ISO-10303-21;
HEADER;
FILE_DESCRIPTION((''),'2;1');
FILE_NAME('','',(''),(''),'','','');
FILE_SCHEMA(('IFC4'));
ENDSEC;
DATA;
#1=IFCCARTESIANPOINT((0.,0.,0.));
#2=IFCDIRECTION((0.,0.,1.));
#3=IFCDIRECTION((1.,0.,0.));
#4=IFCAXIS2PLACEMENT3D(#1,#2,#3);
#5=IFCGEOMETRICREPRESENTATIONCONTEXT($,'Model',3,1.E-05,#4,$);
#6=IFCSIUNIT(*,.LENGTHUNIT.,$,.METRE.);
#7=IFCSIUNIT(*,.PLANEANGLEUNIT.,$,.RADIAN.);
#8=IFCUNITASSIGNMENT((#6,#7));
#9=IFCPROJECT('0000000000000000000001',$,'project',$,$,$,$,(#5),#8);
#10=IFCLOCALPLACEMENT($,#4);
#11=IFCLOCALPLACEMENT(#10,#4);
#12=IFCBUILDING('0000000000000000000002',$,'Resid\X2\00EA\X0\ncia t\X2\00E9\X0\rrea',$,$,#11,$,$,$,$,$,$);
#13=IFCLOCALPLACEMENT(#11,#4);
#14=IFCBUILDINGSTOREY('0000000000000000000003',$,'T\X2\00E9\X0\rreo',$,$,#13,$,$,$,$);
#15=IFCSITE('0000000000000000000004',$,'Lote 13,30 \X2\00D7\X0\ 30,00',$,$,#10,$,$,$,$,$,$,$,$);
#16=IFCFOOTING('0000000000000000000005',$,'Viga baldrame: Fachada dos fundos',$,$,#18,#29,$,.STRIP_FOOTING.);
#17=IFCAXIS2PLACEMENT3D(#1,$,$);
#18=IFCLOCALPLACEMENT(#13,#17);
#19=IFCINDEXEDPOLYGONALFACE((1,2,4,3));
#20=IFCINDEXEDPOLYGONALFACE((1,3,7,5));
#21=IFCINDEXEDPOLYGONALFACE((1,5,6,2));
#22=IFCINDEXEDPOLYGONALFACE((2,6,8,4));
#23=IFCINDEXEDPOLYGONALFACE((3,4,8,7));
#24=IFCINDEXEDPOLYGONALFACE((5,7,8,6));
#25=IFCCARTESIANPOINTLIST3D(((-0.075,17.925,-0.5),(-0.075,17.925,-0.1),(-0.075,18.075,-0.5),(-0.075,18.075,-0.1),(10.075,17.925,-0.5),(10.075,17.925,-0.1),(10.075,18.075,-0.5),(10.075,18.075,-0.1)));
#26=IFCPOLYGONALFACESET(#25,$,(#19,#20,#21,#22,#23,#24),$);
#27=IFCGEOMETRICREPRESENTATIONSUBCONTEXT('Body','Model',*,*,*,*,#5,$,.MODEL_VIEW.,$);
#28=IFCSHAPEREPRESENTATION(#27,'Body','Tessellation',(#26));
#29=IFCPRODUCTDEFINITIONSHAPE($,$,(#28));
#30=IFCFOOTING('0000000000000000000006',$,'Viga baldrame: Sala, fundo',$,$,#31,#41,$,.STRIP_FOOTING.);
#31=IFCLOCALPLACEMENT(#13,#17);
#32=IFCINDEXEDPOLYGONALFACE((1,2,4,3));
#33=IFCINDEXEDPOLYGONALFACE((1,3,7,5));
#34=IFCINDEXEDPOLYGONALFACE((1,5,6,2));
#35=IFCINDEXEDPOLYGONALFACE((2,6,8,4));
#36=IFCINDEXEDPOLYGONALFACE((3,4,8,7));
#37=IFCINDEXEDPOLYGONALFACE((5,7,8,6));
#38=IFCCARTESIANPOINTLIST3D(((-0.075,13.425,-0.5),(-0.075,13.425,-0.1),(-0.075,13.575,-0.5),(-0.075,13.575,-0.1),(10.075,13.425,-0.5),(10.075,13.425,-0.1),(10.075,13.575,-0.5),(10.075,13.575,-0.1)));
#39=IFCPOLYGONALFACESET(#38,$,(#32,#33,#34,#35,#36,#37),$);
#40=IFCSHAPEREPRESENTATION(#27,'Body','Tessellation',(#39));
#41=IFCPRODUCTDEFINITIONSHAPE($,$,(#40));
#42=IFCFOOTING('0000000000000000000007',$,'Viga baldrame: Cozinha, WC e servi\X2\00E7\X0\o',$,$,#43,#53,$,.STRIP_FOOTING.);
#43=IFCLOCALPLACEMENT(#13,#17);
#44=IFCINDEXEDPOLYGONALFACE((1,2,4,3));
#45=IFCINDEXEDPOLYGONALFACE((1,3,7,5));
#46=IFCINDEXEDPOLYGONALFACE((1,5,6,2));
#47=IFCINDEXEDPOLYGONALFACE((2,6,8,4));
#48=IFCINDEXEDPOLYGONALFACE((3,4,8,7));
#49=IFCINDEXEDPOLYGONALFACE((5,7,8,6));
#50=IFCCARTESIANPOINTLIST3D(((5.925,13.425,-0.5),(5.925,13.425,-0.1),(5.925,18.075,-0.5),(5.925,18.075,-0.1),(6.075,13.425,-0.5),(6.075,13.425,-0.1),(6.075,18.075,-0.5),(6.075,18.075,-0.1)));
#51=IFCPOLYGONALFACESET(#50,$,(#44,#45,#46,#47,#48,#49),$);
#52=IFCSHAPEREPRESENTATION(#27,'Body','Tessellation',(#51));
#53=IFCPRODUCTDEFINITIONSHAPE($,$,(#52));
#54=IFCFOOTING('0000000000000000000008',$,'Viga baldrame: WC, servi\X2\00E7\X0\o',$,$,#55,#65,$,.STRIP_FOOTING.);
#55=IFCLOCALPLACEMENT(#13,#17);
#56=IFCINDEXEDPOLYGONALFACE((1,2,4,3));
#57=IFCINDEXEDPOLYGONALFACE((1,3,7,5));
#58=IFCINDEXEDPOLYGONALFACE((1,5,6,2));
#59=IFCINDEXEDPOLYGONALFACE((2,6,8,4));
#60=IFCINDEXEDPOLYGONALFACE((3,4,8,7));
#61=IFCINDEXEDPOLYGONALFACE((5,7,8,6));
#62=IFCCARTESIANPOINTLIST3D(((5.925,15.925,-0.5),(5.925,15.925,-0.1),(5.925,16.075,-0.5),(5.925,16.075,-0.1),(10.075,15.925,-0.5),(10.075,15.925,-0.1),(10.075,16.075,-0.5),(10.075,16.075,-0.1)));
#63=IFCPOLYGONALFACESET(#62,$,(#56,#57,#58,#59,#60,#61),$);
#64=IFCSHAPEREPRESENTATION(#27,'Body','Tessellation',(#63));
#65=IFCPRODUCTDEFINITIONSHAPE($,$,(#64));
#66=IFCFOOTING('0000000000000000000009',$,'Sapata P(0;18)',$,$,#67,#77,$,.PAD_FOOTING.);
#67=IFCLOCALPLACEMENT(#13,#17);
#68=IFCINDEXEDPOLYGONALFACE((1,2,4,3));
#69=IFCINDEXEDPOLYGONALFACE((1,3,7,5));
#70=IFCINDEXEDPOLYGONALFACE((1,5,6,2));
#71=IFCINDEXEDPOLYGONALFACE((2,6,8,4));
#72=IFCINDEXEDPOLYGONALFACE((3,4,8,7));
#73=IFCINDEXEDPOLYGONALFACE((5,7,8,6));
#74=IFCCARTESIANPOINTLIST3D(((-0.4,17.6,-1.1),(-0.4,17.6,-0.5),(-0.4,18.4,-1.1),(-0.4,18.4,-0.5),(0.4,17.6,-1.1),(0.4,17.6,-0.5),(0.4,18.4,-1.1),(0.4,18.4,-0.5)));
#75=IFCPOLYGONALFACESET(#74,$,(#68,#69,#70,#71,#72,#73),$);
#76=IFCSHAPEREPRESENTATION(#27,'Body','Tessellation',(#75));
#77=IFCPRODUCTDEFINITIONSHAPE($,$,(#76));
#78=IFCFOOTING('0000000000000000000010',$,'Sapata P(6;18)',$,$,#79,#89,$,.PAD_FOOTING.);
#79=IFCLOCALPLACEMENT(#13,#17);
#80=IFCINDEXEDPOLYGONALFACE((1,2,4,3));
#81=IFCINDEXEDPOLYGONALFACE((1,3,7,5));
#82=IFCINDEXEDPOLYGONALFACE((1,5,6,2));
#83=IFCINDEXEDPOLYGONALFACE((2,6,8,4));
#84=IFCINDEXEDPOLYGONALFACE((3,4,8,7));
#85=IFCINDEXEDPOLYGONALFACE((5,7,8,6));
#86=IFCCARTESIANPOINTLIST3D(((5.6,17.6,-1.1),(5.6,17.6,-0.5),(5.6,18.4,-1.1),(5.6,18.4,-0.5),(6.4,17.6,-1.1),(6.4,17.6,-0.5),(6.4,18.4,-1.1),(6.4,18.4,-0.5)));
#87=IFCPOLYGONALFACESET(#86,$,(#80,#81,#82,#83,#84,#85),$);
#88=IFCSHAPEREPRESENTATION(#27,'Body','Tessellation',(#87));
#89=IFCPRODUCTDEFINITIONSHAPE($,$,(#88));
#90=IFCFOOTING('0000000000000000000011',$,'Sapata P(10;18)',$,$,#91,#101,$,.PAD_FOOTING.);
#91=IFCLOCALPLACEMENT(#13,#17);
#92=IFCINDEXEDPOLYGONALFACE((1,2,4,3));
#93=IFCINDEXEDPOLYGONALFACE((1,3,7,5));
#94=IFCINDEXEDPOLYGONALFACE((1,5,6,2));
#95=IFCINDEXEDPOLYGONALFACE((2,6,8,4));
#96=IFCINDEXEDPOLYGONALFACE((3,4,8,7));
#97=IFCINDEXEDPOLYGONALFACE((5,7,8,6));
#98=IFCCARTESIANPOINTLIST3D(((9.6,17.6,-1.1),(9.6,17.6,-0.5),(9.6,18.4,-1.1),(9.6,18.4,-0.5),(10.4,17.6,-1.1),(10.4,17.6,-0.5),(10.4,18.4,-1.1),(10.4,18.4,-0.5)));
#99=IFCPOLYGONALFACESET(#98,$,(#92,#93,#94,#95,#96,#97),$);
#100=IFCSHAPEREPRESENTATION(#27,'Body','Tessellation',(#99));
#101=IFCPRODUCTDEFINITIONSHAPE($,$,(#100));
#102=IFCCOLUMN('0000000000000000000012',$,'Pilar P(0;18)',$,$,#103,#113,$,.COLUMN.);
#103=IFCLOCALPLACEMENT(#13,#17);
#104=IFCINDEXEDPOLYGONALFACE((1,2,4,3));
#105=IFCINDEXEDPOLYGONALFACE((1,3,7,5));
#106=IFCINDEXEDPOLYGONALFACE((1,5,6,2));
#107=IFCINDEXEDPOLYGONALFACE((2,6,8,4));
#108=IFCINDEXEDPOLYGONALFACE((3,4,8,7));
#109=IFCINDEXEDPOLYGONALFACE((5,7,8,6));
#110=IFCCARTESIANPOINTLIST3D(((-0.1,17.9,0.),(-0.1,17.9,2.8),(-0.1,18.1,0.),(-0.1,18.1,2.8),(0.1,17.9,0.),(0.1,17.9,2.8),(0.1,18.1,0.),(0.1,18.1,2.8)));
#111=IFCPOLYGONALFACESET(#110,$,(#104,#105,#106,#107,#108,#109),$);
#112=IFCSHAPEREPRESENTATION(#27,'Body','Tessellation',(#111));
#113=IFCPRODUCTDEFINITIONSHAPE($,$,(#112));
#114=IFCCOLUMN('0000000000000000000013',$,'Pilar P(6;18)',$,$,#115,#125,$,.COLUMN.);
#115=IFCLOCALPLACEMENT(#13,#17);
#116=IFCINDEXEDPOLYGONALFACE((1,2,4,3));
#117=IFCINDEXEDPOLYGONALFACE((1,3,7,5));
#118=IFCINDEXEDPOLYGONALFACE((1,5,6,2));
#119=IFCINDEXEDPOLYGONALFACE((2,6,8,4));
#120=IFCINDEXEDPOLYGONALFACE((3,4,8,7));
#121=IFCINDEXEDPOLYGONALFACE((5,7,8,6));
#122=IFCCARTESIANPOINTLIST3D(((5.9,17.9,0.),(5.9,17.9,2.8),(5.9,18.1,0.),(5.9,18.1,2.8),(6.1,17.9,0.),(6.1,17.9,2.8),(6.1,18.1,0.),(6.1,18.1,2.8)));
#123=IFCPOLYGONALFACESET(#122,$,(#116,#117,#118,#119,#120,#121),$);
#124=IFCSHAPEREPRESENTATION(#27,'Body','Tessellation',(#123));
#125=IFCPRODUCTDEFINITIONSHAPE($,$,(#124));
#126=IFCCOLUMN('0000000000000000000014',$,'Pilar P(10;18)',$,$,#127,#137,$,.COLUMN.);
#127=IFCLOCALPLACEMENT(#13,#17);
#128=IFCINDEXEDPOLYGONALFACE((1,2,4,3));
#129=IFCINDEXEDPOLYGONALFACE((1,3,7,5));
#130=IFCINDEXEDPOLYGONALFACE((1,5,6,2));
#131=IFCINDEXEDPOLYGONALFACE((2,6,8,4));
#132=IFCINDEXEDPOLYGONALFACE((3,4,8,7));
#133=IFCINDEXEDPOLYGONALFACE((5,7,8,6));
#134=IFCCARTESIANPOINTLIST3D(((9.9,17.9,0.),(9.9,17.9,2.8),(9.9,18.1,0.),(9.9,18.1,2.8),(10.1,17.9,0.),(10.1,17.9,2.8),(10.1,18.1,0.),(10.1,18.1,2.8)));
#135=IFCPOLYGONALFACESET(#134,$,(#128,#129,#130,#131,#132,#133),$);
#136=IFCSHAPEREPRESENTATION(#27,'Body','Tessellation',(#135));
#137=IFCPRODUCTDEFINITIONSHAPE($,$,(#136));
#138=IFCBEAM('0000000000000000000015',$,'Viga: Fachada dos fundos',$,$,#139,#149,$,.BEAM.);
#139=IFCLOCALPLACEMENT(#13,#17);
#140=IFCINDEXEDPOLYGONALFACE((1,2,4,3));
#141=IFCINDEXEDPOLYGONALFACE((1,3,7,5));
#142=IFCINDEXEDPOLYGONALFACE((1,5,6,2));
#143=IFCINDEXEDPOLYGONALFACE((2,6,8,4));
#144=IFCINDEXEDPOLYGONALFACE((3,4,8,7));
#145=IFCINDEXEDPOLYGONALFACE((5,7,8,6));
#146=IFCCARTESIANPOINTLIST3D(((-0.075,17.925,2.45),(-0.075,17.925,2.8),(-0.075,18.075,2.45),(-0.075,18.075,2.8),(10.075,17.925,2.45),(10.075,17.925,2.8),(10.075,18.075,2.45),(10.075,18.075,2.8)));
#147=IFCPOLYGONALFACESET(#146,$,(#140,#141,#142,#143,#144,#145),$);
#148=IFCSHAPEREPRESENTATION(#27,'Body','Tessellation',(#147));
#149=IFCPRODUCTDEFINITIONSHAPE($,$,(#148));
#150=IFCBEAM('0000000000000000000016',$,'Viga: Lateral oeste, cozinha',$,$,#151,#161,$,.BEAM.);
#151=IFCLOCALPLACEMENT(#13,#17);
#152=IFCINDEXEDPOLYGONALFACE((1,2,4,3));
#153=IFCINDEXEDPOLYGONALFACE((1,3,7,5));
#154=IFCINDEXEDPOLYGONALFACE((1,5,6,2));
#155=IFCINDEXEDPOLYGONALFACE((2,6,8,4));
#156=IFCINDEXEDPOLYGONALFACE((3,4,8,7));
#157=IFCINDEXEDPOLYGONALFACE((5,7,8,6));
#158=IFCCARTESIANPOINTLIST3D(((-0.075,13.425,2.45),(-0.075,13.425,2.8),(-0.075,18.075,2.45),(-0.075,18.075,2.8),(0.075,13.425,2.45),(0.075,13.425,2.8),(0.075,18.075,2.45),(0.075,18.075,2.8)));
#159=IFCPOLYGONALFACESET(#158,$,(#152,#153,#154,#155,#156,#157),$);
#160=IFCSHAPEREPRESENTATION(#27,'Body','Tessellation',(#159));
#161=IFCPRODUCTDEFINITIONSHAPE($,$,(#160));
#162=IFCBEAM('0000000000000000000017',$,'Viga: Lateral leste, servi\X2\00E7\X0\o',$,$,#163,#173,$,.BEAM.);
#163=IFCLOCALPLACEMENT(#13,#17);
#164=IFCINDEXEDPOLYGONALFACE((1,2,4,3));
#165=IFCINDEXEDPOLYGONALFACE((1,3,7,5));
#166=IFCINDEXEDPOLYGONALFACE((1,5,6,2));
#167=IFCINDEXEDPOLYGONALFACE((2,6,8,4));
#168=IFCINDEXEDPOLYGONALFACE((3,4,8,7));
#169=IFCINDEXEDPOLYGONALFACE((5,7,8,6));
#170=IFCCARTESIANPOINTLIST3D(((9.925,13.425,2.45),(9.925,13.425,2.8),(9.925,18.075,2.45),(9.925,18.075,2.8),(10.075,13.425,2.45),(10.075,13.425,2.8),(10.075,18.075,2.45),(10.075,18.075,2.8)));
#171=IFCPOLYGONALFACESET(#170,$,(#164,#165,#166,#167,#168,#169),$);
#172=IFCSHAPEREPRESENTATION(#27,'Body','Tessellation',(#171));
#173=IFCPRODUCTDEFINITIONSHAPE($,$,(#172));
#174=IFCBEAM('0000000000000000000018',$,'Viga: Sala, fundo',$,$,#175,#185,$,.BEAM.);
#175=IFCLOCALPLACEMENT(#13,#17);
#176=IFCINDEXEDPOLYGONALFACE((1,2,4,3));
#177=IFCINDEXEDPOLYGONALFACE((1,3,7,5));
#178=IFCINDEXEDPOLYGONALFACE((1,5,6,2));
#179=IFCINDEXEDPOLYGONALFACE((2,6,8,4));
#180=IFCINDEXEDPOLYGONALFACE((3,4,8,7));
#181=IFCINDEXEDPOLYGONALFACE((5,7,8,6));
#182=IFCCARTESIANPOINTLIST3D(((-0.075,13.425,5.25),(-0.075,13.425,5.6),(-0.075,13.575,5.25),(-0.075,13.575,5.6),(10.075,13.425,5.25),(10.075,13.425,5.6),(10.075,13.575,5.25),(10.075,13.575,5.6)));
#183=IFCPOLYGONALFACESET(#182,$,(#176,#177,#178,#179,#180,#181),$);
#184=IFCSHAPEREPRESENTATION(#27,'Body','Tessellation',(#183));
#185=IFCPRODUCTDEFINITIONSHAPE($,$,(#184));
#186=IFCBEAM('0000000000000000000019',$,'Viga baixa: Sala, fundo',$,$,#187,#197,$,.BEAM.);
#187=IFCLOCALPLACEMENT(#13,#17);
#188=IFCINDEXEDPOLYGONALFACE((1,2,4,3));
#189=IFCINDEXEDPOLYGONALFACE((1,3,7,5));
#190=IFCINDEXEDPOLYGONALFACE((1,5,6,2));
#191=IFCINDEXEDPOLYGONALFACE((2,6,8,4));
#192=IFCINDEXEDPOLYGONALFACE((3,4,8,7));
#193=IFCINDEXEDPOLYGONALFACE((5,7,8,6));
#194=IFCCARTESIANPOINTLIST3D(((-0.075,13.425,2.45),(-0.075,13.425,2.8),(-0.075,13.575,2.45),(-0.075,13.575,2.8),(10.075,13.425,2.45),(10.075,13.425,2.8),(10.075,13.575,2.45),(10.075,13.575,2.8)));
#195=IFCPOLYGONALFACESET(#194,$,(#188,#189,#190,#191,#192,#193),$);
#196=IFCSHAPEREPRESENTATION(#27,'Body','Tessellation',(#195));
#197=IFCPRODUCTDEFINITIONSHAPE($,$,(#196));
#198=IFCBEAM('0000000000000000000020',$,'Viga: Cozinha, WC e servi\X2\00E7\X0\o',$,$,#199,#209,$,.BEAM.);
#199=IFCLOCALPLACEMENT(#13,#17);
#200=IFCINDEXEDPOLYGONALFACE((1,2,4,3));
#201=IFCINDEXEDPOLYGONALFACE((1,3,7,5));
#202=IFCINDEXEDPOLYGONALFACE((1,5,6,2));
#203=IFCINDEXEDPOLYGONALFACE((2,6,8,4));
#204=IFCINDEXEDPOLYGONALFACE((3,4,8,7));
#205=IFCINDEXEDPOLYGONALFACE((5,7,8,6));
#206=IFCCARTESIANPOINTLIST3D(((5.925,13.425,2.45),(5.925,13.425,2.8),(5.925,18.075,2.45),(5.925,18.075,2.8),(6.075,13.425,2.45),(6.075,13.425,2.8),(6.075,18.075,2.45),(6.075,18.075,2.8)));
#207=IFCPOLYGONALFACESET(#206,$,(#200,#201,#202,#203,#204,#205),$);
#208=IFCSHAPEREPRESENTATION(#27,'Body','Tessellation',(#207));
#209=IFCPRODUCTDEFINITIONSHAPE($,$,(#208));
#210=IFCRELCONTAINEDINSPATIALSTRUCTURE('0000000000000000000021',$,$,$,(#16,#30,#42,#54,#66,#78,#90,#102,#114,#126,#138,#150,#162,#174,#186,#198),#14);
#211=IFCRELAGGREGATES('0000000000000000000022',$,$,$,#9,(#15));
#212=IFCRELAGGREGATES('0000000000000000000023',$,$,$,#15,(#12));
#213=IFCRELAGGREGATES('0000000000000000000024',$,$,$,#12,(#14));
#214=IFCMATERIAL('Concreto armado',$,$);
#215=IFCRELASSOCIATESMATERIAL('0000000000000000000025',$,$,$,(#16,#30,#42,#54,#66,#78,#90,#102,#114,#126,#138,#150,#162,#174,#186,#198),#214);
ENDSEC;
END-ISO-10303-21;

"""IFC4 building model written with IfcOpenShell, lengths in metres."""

from ifc_helpers import new_model, si_unit, frame, origin_with_axes, place, context, subcontext, project, spatial, line, indexed_curve, outline, extrude, material, element, save


model = new_model("IFC4")

# Units and contexts
model_context = context("Model", 3, precision=1e-05, world=origin_with_axes())
body_context = subcontext(model_context, "Body", "Model", "MODEL_VIEW")
ifc_project = project(units=[si_unit("LENGTHUNIT", "METRE"), si_unit("PLANEANGLEUNIT", "RADIAN")], contexts=[model_context])

# Site, building, storey
site_placement = place(None, origin_with_axes())
site = spatial("IfcSite", under=ifc_project, at=site_placement, Name="Lote 13,30 × 30,00")
building_placement = place(site_placement, origin_with_axes())
building = spatial("IfcBuilding", under=site, at=building_placement, Name="Residência térrea")
storey_placement = place(building_placement, origin_with_axes())
storey = spatial("IfcBuildingStorey", under=building, at=storey_placement, Name="Térreo")

# Footings
ifc_material_1 = material(Name="Concreto armado")
for number, where, z_axis, x_axis, name in (
    (1, (-0.075, 17.925, -0.5), (0.0, 0.0, 1.0), (1.0, 0.0, 0.0), "Viga baldrame: Fachada dos fundos"),
    (2, (-0.075, 13.425, -0.5), (0.0, 0.0, 1.0), (1.0, 0.0, 0.0), "Viga baldrame: Sala, fundo"),
):
    element("IfcFooting", number, at=place(storey_placement, frame(where, z_axis=z_axis, x_axis=x_axis)), inside=storey, material=ifc_material_1, Name=name, PredefinedType="STRIP_FOOTING", context=body_context, shape_type="SweptSolid", body=[
        extrude(outline(indexed_curve([(0.0, 0.0), (10.15, 0.0), (10.15, 0.15), (0.0, 0.15)], segments=[line(1, 2, 3, 4, 1)])), origin_with_axes(), (0.0, 0.0, 1.0), 0.4),
    ])
footing_1_placement = place(storey_placement, frame((5.925, 13.425, -0.5), z_axis=(0.0, 0.0, 1.0), x_axis=(1.0, 0.0, 0.0)))
element("IfcFooting", 3, at=footing_1_placement, inside=storey, material=ifc_material_1, Name="Viga baldrame: Cozinha, WC e serviço", PredefinedType="STRIP_FOOTING", context=body_context, shape_type="SweptSolid", body=[
    extrude(outline(indexed_curve([(0.0, 0.0), (0.15, 0.0), (0.15, 4.65), (0.0, 4.65)], segments=[line(1, 2, 3, 4, 1)])), origin_with_axes(), (0.0, 0.0, 1.0), 0.4),
])
footing_2_placement = place(storey_placement, frame((5.925, 15.925, -0.5), z_axis=(0.0, 0.0, 1.0), x_axis=(1.0, 0.0, 0.0)))
element("IfcFooting", 4, at=footing_2_placement, inside=storey, material=ifc_material_1, Name="Viga baldrame: WC, serviço", PredefinedType="STRIP_FOOTING", context=body_context, shape_type="SweptSolid", body=[
    extrude(outline(indexed_curve([(0.0, 0.0), (4.15, 0.0), (4.15, 0.15), (0.0, 0.15)], segments=[line(1, 2, 3, 4, 1)])), origin_with_axes(), (0.0, 0.0, 1.0), 0.4),
])
footing_3_placement = place(storey_placement, frame((-0.4, 17.6, -1.1), z_axis=(0.0, 0.0, 1.0), x_axis=(1.0, 0.0, 0.0)))
element("IfcFooting", 5, at=footing_3_placement, inside=storey, material=ifc_material_1, Name="Sapata P(0;18)", PredefinedType="PAD_FOOTING", context=body_context, shape_type="SweptSolid", body=[
    extrude(outline(indexed_curve([(0.0, 0.0), (0.8, 0.0), (0.8, 0.8), (0.0, 0.8)], segments=[line(1, 2, 3, 4, 1)])), origin_with_axes(), (0.0, 0.0, 1.0), 0.6),
])
for number, where, z_axis, x_axis, name in (
    (6, (5.6, 17.6, -1.1), (0.0, 0.0, 1.0), (1.0, 0.0, 0.0), "Sapata P(6;18)"),
    (7, (9.6, 17.6, -1.1), (0.0, 0.0, 1.0), (1.0, 0.0, 0.0), "Sapata P(10;18)"),
):
    element("IfcFooting", number, at=place(storey_placement, frame(where, z_axis=z_axis, x_axis=x_axis)), inside=storey, material=ifc_material_1, Name=name, PredefinedType="PAD_FOOTING", context=body_context, shape_type="SweptSolid", body=[
        extrude(outline(indexed_curve([(0.0, 0.0), (0.8, 0.0), (0.8, 0.8), (0.0, 0.8)], segments=[line(1, 2, 3, 4, 1)])), origin_with_axes(), (0.0, 0.0, 1.0), 0.6),
    ])

# Columns
column_placement = place(storey_placement, frame((-0.1, 17.9, 0.0), z_axis=(0.0, 0.0, 1.0), x_axis=(1.0, 0.0, 0.0)))
element("IfcColumn", 8, at=column_placement, inside=storey, material=ifc_material_1, Name="Pilar P(0;18)", PredefinedType="COLUMN", context=body_context, shape_type="SweptSolid", body=[
    extrude(outline(indexed_curve([(0.0, 0.0), (0.2, 0.0), (0.2, 0.2), (0.0, 0.2)], segments=[line(1, 2, 3, 4, 1)])), origin_with_axes(), (0.0, 0.0, 1.0), 2.8),
])
for number, where, z_axis, x_axis, name in (
    (9, (5.9, 17.9, 0.0), (0.0, 0.0, 1.0), (1.0, 0.0, 0.0), "Pilar P(6;18)"),
    (10, (9.9, 17.9, 0.0), (0.0, 0.0, 1.0), (1.0, 0.0, 0.0), "Pilar P(10;18)"),
):
    element("IfcColumn", number, at=place(storey_placement, frame(where, z_axis=z_axis, x_axis=x_axis)), inside=storey, material=ifc_material_1, Name=name, PredefinedType="COLUMN", context=body_context, shape_type="SweptSolid", body=[
        extrude(outline(indexed_curve([(0.0, 0.0), (0.2, 0.0), (0.2, 0.2), (0.0, 0.2)], segments=[line(1, 2, 3, 4, 1)])), origin_with_axes(), (0.0, 0.0, 1.0), 2.8),
    ])

# Beams
beam_1_placement = place(storey_placement, frame((-0.075, 17.925, 2.45), z_axis=(0.0, 0.0, 1.0), x_axis=(1.0, 0.0, 0.0)))
element("IfcBeam", 11, at=beam_1_placement, inside=storey, material=ifc_material_1, Name="Viga: Fachada dos fundos", PredefinedType="BEAM", context=body_context, shape_type="SweptSolid", body=[
    extrude(outline(indexed_curve([(0.0, 0.0), (10.15, 0.0), (10.15, 0.15), (0.0, 0.15)], segments=[line(1, 2, 3, 4, 1)])), origin_with_axes(), (0.0, 0.0, 1.0), 0.35),
])
beam_2_placement = place(storey_placement, frame((-0.075, 13.425, 2.45), z_axis=(0.0, 0.0, 1.0), x_axis=(1.0, 0.0, 0.0)))
element("IfcBeam", 12, at=beam_2_placement, inside=storey, material=ifc_material_1, Name="Viga: Lateral oeste, cozinha", PredefinedType="BEAM", context=body_context, shape_type="SweptSolid", body=[
    extrude(outline(indexed_curve([(0.0, 0.0), (0.15, 0.0), (0.15, 4.65), (0.0, 4.65)], segments=[line(1, 2, 3, 4, 1)])), origin_with_axes(), (0.0, 0.0, 1.0), 0.35),
])
beam_3_placement = place(storey_placement, frame((9.925, 13.425, 2.45), z_axis=(0.0, 0.0, 1.0), x_axis=(1.0, 0.0, 0.0)))
element("IfcBeam", 13, at=beam_3_placement, inside=storey, material=ifc_material_1, Name="Viga: Lateral leste, serviço", PredefinedType="BEAM", context=body_context, shape_type="SweptSolid", body=[
    extrude(outline(indexed_curve([(0.0, 0.0), (0.15, 0.0), (0.15, 4.65), (0.0, 4.65)], segments=[line(1, 2, 3, 4, 1)])), origin_with_axes(), (0.0, 0.0, 1.0), 0.35),
])
beam_4_placement = place(storey_placement, frame((-0.075, 13.425, 5.25), z_axis=(0.0, 0.0, 1.0), x_axis=(1.0, 0.0, 0.0)))
element("IfcBeam", 14, at=beam_4_placement, inside=storey, material=ifc_material_1, Name="Viga: Sala, fundo", PredefinedType="BEAM", context=body_context, shape_type="SweptSolid", body=[
    extrude(outline(indexed_curve([(0.0, 0.0), (10.15, 0.0), (10.15, 0.15), (0.0, 0.15)], segments=[line(1, 2, 3, 4, 1)])), origin_with_axes(), (0.0, 0.0, 1.0), 0.35),
])
beam_5_placement = place(storey_placement, frame((-0.075, 13.425, 2.45), z_axis=(0.0, 0.0, 1.0), x_axis=(1.0, 0.0, 0.0)))
element("IfcBeam", 15, at=beam_5_placement, inside=storey, material=ifc_material_1, Name="Viga baixa: Sala, fundo", PredefinedType="BEAM", context=body_context, shape_type="SweptSolid", body=[
    extrude(outline(indexed_curve([(0.0, 0.0), (10.15, 0.0), (10.15, 0.15), (0.0, 0.15)], segments=[line(1, 2, 3, 4, 1)])), origin_with_axes(), (0.0, 0.0, 1.0), 0.35),
])
beam_6_placement = place(storey_placement, frame((5.925, 13.425, 2.45), z_axis=(0.0, 0.0, 1.0), x_axis=(1.0, 0.0, 0.0)))
element("IfcBeam", 16, at=beam_6_placement, inside=storey, material=ifc_material_1, Name="Viga: Cozinha, WC e serviço", PredefinedType="BEAM", context=body_context, shape_type="SweptSolid", body=[
    extrude(outline(indexed_curve([(0.0, 0.0), (0.15, 0.0), (0.15, 4.65), (0.0, 4.65)], segments=[line(1, 2, 3, 4, 1)])), origin_with_axes(), (0.0, 0.0, 1.0), 0.35),
])

save(model, "model.ifc")
